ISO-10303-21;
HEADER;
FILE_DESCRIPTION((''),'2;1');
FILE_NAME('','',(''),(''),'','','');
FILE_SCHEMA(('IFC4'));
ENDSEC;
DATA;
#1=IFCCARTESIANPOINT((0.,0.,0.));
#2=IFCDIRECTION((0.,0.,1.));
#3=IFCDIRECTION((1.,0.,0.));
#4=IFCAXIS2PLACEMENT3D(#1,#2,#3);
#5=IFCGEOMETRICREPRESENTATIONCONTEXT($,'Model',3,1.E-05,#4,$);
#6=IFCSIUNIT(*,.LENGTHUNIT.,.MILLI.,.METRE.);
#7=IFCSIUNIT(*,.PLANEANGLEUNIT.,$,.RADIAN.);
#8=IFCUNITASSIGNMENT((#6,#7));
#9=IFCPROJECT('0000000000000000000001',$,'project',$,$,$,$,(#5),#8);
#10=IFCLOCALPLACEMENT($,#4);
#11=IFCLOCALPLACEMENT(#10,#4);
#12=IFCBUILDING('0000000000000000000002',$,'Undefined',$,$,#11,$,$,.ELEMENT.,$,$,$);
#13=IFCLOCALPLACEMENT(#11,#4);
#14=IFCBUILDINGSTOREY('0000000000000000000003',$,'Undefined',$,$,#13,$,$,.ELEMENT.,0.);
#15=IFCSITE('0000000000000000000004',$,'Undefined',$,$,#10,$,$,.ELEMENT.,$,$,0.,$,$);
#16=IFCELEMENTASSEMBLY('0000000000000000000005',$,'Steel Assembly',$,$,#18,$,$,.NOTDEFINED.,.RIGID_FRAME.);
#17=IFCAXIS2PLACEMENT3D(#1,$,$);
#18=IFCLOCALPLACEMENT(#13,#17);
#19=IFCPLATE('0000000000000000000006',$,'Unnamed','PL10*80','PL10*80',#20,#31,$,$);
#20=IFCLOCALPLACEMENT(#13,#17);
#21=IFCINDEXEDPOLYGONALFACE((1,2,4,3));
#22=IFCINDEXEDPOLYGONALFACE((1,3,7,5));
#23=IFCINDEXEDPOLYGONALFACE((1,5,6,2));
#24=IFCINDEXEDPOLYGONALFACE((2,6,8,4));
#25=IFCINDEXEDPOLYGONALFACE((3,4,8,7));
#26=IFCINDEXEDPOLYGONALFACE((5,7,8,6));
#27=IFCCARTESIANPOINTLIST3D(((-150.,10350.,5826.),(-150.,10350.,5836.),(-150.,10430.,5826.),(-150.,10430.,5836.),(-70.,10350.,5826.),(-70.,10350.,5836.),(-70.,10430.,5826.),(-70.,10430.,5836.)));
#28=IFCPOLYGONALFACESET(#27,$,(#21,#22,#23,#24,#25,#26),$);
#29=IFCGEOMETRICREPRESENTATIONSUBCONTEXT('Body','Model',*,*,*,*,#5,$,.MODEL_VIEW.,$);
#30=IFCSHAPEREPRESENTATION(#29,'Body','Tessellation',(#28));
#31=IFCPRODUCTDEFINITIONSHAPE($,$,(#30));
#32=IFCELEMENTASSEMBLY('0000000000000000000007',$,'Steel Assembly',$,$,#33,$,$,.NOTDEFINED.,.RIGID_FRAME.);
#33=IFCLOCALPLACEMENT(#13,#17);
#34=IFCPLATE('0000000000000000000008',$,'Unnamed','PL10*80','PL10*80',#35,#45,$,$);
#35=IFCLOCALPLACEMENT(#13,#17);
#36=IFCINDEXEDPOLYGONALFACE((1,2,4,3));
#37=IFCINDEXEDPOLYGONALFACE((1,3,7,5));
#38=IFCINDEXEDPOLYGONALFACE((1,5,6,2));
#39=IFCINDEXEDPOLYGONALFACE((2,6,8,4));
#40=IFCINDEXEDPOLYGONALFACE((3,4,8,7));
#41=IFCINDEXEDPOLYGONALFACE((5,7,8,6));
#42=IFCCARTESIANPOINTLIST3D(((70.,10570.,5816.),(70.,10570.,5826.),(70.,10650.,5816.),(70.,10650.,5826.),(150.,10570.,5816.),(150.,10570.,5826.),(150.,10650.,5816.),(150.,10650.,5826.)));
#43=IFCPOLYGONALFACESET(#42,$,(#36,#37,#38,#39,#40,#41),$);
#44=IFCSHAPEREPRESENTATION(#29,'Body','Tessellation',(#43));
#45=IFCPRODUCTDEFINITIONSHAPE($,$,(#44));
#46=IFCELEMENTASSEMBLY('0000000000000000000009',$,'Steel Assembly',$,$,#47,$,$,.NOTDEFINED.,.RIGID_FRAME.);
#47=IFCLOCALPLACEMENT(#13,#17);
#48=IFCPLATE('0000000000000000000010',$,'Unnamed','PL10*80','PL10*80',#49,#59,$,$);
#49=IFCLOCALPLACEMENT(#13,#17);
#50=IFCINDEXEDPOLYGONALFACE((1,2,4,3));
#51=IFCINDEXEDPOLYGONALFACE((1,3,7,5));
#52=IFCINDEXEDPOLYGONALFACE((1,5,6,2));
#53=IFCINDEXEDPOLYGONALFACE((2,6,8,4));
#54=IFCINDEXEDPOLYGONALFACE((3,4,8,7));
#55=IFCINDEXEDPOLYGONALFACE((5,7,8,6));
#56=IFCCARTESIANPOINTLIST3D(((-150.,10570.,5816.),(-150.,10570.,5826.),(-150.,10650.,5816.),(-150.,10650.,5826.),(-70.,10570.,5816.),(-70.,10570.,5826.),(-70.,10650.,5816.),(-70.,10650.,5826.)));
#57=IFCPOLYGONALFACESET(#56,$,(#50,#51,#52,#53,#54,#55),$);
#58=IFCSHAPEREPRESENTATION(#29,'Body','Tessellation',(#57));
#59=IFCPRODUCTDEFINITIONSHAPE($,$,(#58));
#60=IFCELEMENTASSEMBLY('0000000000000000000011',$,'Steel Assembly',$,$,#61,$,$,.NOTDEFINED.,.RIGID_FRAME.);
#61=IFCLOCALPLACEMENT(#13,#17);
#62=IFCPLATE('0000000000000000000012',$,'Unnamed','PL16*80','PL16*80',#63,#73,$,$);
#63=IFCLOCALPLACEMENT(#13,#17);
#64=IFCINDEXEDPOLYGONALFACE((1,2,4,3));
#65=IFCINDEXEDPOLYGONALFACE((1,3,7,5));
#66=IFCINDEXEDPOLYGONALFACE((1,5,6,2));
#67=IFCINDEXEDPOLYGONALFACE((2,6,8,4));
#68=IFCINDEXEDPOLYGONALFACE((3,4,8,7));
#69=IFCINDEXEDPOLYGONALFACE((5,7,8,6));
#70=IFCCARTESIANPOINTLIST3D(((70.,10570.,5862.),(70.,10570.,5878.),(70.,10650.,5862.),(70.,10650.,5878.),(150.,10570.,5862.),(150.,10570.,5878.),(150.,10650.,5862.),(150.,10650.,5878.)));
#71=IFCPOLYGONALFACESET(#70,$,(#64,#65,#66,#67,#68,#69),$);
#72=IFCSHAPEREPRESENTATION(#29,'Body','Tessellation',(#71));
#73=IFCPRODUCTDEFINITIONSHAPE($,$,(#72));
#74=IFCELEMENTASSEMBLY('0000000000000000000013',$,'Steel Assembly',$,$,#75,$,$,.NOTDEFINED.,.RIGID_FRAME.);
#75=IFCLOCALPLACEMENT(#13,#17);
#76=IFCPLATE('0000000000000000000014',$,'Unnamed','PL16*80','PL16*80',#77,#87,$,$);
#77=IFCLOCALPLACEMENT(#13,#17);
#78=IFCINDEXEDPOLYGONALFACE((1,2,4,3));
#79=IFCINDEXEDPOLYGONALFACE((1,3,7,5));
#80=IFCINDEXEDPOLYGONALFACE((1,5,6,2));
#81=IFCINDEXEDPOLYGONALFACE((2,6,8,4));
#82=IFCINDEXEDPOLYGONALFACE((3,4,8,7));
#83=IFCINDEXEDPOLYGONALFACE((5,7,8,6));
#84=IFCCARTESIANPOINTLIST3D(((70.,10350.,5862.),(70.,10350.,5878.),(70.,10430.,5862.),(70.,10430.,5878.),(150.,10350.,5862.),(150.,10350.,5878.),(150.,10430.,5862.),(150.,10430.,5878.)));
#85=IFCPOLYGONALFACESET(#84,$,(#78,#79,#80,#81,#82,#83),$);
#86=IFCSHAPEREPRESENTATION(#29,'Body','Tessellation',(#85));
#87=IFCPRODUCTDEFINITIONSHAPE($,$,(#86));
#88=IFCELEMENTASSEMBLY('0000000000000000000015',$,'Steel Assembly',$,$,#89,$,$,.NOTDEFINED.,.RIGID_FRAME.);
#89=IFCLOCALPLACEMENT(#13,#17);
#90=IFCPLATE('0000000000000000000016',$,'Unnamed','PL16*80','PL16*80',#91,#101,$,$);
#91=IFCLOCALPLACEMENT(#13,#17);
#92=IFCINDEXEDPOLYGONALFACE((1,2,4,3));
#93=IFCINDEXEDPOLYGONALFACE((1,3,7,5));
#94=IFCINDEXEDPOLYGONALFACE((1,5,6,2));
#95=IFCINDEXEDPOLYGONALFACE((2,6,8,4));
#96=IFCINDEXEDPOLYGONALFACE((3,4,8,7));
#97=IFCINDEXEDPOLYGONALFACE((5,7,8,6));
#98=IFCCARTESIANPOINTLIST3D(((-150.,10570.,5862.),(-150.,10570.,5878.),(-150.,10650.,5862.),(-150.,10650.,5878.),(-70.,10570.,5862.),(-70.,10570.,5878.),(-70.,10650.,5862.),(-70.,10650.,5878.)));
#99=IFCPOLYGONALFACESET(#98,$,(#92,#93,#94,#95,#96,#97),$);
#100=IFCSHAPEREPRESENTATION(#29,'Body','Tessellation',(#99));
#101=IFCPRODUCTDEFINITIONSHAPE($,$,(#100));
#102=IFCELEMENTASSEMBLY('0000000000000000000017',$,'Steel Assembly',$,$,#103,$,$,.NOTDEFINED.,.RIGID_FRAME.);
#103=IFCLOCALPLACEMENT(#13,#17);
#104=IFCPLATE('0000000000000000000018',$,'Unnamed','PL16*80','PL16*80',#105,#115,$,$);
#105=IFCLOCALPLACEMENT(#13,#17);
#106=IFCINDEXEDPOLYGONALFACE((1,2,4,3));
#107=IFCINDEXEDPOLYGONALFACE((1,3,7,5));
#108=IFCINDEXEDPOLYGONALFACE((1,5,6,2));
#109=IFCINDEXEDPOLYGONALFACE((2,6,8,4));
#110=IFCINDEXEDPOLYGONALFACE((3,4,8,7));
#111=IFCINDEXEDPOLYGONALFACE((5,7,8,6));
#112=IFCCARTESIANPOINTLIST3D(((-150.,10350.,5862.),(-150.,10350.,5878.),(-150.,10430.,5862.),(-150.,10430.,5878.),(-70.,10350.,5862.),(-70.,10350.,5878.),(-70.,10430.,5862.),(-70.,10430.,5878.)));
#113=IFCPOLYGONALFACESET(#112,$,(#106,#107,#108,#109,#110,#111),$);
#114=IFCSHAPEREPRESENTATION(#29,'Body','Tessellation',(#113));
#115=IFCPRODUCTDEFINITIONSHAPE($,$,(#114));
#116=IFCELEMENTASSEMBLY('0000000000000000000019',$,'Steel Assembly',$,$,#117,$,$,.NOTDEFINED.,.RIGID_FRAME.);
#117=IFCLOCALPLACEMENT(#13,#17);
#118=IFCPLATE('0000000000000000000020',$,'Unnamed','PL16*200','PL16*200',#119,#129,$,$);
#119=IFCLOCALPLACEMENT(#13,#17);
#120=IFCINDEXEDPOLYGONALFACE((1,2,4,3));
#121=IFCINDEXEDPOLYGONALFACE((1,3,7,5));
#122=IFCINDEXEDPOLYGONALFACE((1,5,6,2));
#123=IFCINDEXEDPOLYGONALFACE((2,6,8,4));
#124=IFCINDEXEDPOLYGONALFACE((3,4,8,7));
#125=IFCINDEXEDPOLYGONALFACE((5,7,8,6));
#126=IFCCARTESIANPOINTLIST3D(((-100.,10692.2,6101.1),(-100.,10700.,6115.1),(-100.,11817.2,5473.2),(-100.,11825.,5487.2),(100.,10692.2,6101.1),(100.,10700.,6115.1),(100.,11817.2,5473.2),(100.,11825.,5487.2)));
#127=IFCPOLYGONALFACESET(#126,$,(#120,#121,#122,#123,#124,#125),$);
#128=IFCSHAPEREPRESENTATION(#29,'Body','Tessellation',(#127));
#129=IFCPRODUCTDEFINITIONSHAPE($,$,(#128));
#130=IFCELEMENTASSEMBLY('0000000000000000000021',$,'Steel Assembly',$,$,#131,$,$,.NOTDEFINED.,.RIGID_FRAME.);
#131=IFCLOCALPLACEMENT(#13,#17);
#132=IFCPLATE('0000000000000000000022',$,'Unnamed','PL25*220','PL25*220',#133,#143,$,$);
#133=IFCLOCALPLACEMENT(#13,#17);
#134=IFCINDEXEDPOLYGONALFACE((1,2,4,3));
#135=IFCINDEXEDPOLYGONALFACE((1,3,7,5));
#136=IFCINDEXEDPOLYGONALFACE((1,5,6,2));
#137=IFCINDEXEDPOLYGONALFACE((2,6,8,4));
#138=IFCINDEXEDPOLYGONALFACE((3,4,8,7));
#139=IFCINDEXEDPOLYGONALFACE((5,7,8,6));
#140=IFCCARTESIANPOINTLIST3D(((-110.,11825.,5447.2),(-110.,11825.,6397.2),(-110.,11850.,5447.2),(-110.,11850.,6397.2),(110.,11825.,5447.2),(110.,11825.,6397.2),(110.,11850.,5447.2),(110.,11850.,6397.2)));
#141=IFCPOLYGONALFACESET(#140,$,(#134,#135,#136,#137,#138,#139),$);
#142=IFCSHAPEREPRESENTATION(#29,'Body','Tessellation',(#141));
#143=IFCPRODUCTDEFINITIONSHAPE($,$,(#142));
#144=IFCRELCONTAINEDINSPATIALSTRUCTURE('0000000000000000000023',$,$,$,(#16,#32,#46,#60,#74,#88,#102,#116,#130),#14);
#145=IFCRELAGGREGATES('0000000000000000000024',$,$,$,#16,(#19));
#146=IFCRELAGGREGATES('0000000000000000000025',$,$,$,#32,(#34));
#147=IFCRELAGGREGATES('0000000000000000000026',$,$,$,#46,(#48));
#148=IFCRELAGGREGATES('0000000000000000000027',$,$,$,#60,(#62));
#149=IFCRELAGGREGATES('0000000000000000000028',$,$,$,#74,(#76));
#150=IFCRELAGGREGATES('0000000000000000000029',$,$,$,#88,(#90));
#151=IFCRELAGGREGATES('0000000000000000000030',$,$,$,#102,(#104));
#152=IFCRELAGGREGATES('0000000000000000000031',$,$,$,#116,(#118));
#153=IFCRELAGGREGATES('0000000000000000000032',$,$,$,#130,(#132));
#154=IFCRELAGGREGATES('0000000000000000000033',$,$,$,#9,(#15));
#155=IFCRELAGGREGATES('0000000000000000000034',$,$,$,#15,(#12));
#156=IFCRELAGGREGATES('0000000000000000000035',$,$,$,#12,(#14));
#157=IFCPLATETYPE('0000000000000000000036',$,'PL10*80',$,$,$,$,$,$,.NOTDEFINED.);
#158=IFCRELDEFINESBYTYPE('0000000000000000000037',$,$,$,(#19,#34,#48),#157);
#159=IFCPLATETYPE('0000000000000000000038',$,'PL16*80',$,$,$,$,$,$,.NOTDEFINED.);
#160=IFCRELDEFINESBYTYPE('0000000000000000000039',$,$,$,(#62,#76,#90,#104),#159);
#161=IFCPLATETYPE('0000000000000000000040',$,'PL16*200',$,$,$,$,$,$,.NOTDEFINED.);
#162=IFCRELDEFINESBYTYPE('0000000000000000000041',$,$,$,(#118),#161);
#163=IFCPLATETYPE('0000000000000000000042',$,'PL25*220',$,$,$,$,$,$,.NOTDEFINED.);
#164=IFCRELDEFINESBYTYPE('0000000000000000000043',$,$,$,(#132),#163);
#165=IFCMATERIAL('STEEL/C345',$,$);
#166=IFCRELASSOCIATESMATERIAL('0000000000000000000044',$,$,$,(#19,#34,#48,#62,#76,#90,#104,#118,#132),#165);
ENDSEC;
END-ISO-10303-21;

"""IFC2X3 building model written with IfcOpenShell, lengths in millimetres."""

from ifc_helpers import new_model, si_unit, frame, origin_with_axes, place, context, subcontext, project, spatial, polyline, outline, extrude, material, type_object, element, aggregate, save


model = new_model("IFC2X3")

# Units and contexts
model_context = context("Model", 3, precision=1e-05, world=origin_with_axes())
body_context = subcontext(model_context, "Body", "Model", "MODEL_VIEW")
ifc_project = project(units=[si_unit("LENGTHUNIT", "METRE", prefix="MILLI"), si_unit("PLANEANGLEUNIT", "RADIAN")], contexts=[model_context])

# Site, building, storey
site_placement = place(None, origin_with_axes())
site = spatial("IfcSite", under=ifc_project, at=site_placement, Name="Undefined", CompositionType="ELEMENT", RefElevation=0.0)
building_placement = place(site_placement, origin_with_axes())
building = spatial("IfcBuilding", under=site, at=building_placement, Name="Undefined", CompositionType="ELEMENT")
storey_placement = place(building_placement, origin_with_axes())
storey = spatial("IfcBuildingStorey", under=building, at=storey_placement, Name="Undefined", CompositionType="ELEMENT", Elevation=0.0)

# Shared definitions
ifc_material = material(Name="STEEL/C345")

# Element assemblies, plates
plate_type_1 = type_object("IfcPlateType", Name="PL10*80", PredefinedType="NOTDEFINED")
assembly_1_placement = place(storey_placement, origin_with_axes())
assembly_1 = element("IfcElementAssembly", 1, at=assembly_1_placement, inside=storey, Name="Steel Assembly", AssemblyPlace="NOTDEFINED", PredefinedType="RIGID_FRAME")
plate_1_placement = place(assembly_1_placement, frame((-150.0, 10350.0, 5831.0), z_axis=(0.0, 0.0, -1.0), x_axis=(0.0, 1.0, 0.0)))
plate_1 = element("IfcPlate", 2, at=plate_1_placement, type_object=plate_type_1, material=ifc_material, Name="Unnamed", Description="PL10*80", ObjectType="PL10*80", context=body_context, shape_type="SweptSolid", body=[
    extrude(outline(polyline([(0.0, 0.0), (80.0, 0.0), (80.0, 80.0), (0.0, 80.0), (0.0, 0.0)])), frame((0.0, 0.0, -5.0), z_axis=(0.0, 0.0, 1.0), x_axis=(1.0, 0.0, 0.0)), (0.0, 0.0, 1.0), 10.0),
])
aggregate(assembly_1, [plate_1])
assembly_2_placement = place(storey_placement, origin_with_axes())
assembly_2 = element("IfcElementAssembly", 3, at=assembly_2_placement, inside=storey, Name="Steel Assembly", AssemblyPlace="NOTDEFINED", PredefinedType="RIGID_FRAME")
plate_2_placement = place(assembly_2_placement, frame((150.0, 10650.0, 5821.0), z_axis=(0.0, 0.0, -1.0), x_axis=(0.0, -1.0, 0.0)))
plate_2 = element("IfcPlate", 4, at=plate_2_placement, type_object=plate_type_1, material=ifc_material, Name="Unnamed", Description="PL10*80", ObjectType="PL10*80", context=body_context, shape_type="SweptSolid", body=[
    extrude(outline(polyline([(0.0, 0.0), (80.0, 0.0), (80.0, 80.0), (0.0, 80.0), (0.0, 0.0)])), frame((0.0, 0.0, -5.0), z_axis=(0.0, 0.0, 1.0), x_axis=(1.0, 0.0, 0.0)), (0.0, 0.0, 1.0), 10.0),
])
aggregate(assembly_2, [plate_2])
assembly_3_placement = place(storey_placement, origin_with_axes())
assembly_3 = element("IfcElementAssembly", 5, at=assembly_3_placement, inside=storey, Name="Steel Assembly", AssemblyPlace="NOTDEFINED", PredefinedType="RIGID_FRAME")
plate_3_placement = place(assembly_3_placement, frame((-150.0, 10650.0, 5821.0), z_axis=(0.0, 0.0, 1.0), x_axis=(0.0, -1.0, 0.0)))
plate_3 = element("IfcPlate", 6, at=plate_3_placement, type_object=plate_type_1, material=ifc_material, Name="Unnamed", Description="PL10*80", ObjectType="PL10*80", context=body_context, shape_type="SweptSolid", body=[
    extrude(outline(polyline([(0.0, 0.0), (80.0, 0.0), (80.0, 80.0), (0.0, 80.0), (0.0, 0.0)])), frame((0.0, 0.0, -5.0), z_axis=(0.0, 0.0, 1.0), x_axis=(1.0, 0.0, 0.0)), (0.0, 0.0, 1.0), 10.0),
])
aggregate(assembly_3, [plate_3])
assembly_4_placement = place(storey_placement, origin_with_axes())
assembly_4 = element("IfcElementAssembly", 7, at=assembly_4_placement, inside=storey, Name="Steel Assembly", AssemblyPlace="NOTDEFINED", PredefinedType="RIGID_FRAME")
plate_type_2 = type_object("IfcPlateType", Name="PL16*80", PredefinedType="NOTDEFINED")
plate_4_placement = place(assembly_4_placement, frame((150.0, 10650.0, 5870.0), z_axis=(0.0, 0.0, -1.0), x_axis=(0.0, -1.0, 0.0)))
plate_4 = element("IfcPlate", 8, at=plate_4_placement, type_object=plate_type_2, material=ifc_material, Name="Unnamed", Description="PL16*80", ObjectType="PL16*80", context=body_context, shape_type="SweptSolid", body=[
    extrude(outline(polyline([(0.0, 0.0), (80.0, 0.0), (80.0, 80.0), (0.0, 80.0), (0.0, 0.0)])), frame((0.0, 0.0, -8.0), z_axis=(0.0, 0.0, 1.0), x_axis=(1.0, 0.0, 0.0)), (0.0, 0.0, 1.0), 16.0),
])
aggregate(assembly_4, [plate_4])
assembly_5_placement = place(storey_placement, origin_with_axes())
assembly_5 = element("IfcElementAssembly", 9, at=assembly_5_placement, inside=storey, Name="Steel Assembly", AssemblyPlace="NOTDEFINED", PredefinedType="RIGID_FRAME")
plate_5_placement = place(assembly_5_placement, frame((150.0, 10350.0, 5870.0), z_axis=(0.0, 0.0, 1.0), x_axis=(0.0, 1.0, 0.0)))
plate_5 = element("IfcPlate", 10, at=plate_5_placement, type_object=plate_type_2, material=ifc_material, Name="Unnamed", Description="PL16*80", ObjectType="PL16*80", context=body_context, shape_type="SweptSolid", body=[
    extrude(outline(polyline([(0.0, 0.0), (80.0, 0.0), (80.0, 80.0), (0.0, 80.0), (0.0, 0.0)])), frame((0.0, 0.0, -8.0), z_axis=(0.0, 0.0, 1.0), x_axis=(1.0, 0.0, 0.0)), (0.0, 0.0, 1.0), 16.0),
])
aggregate(assembly_5, [plate_5])
assembly_6_placement = place(storey_placement, origin_with_axes())
assembly_6 = element("IfcElementAssembly", 11, at=assembly_6_placement, inside=storey, Name="Steel Assembly", AssemblyPlace="NOTDEFINED", PredefinedType="RIGID_FRAME")
plate_6_placement = place(assembly_6_placement, frame((-150.0, 10650.0, 5870.0), z_axis=(0.0, 0.0, 1.0), x_axis=(0.0, -1.0, 0.0)))
plate_6 = element("IfcPlate", 12, at=plate_6_placement, type_object=plate_type_2, material=ifc_material, Name="Unnamed", Description="PL16*80", ObjectType="PL16*80", context=body_context, shape_type="SweptSolid", body=[
    extrude(outline(polyline([(0.0, 0.0), (80.0, 0.0), (80.0, 80.0), (0.0, 80.0), (0.0, 0.0)])), frame((0.0, 0.0, -8.0), z_axis=(0.0, 0.0, 1.0), x_axis=(1.0, 0.0, 0.0)), (0.0, 0.0, 1.0), 16.0),
])
aggregate(assembly_6, [plate_6])
assembly_7_placement = place(storey_placement, origin_with_axes())
assembly_7 = element("IfcElementAssembly", 13, at=assembly_7_placement, inside=storey, Name="Steel Assembly", AssemblyPlace="NOTDEFINED", PredefinedType="RIGID_FRAME")
plate_7_placement = place(assembly_7_placement, frame((-150.0, 10350.0, 5870.0), z_axis=(0.0, 0.0, -1.0), x_axis=(0.0, 1.0, 0.0)))
plate_7 = element("IfcPlate", 14, at=plate_7_placement, type_object=plate_type_2, material=ifc_material, Name="Unnamed", Description="PL16*80", ObjectType="PL16*80", context=body_context, shape_type="SweptSolid", body=[
    extrude(outline(polyline([(0.0, 0.0), (80.0, 0.0), (80.0, 80.0), (0.0, 80.0), (0.0, 0.0)])), frame((0.0, 0.0, -8.0), z_axis=(0.0, 0.0, 1.0), x_axis=(1.0, 0.0, 0.0)), (0.0, 0.0, 1.0), 16.0),
])
aggregate(assembly_7, [plate_7])
assembly_8_placement = place(storey_placement, origin_with_axes())
assembly_8 = element("IfcElementAssembly", 15, at=assembly_8_placement, inside=storey, Name="Steel Assembly", AssemblyPlace="NOTDEFINED", PredefinedType="RIGID_FRAME")
plate_type_3 = type_object("IfcPlateType", Name="PL16*200", PredefinedType="NOTDEFINED")
plate_8_placement = place(assembly_8_placement, frame((100.0, 11821.1, 5480.2), z_axis=(0.0, 0.487361, 0.8732), x_axis=(-1.0, 0.0, 0.0)))
plate_8 = element("IfcPlate", 16, at=plate_8_placement, type_object=plate_type_3, material=ifc_material, Name="Unnamed", Description="PL16*200", ObjectType="PL16*200", context=body_context, shape_type="SweptSolid", body=[
    extrude(outline(polyline([(0.0, 0.0), (200.0, 0.0), (200.0, 1288.4), (0.0, 1288.4), (0.0, 0.0)])), frame((0.0, 0.0, -8.0), z_axis=(0.0, 0.0, 1.0), x_axis=(1.0, 0.0, 0.0)), (0.0, 0.0, 1.0), 16.0),
])
aggregate(assembly_8, [plate_8])
assembly_9_placement = place(storey_placement, origin_with_axes())
assembly_9 = element("IfcElementAssembly", 17, at=assembly_9_placement, inside=storey, Name="Steel Assembly", AssemblyPlace="NOTDEFINED", PredefinedType="RIGID_FRAME")
plate_type_4 = type_object("IfcPlateType", Name="PL25*220", PredefinedType="NOTDEFINED")
plate_9_placement = place(assembly_9_placement, frame((110.0, 11837.5, 5447.2), z_axis=(0.0, -1.0, 0.0), x_axis=(0.0, 0.0, 1.0)))
plate_9 = element("IfcPlate", 18, at=plate_9_placement, type_object=plate_type_4, material=ifc_material, Name="Unnamed", Description="PL25*220", ObjectType="PL25*220", context=body_context, shape_type="SweptSolid", body=[
    extrude(outline(polyline([(0.0, 0.0), (950.0, 0.0), (950.0, 220.0), (0.0, 220.0), (0.0, 0.0)])), frame((0.0, 0.0, -12.5), z_axis=(0.0, 0.0, 1.0), x_axis=(1.0, 0.0, 0.0)), (0.0, 0.0, 1.0), 25.0),
])
aggregate(assembly_9, [plate_9])

save(model, "model.ifc")
